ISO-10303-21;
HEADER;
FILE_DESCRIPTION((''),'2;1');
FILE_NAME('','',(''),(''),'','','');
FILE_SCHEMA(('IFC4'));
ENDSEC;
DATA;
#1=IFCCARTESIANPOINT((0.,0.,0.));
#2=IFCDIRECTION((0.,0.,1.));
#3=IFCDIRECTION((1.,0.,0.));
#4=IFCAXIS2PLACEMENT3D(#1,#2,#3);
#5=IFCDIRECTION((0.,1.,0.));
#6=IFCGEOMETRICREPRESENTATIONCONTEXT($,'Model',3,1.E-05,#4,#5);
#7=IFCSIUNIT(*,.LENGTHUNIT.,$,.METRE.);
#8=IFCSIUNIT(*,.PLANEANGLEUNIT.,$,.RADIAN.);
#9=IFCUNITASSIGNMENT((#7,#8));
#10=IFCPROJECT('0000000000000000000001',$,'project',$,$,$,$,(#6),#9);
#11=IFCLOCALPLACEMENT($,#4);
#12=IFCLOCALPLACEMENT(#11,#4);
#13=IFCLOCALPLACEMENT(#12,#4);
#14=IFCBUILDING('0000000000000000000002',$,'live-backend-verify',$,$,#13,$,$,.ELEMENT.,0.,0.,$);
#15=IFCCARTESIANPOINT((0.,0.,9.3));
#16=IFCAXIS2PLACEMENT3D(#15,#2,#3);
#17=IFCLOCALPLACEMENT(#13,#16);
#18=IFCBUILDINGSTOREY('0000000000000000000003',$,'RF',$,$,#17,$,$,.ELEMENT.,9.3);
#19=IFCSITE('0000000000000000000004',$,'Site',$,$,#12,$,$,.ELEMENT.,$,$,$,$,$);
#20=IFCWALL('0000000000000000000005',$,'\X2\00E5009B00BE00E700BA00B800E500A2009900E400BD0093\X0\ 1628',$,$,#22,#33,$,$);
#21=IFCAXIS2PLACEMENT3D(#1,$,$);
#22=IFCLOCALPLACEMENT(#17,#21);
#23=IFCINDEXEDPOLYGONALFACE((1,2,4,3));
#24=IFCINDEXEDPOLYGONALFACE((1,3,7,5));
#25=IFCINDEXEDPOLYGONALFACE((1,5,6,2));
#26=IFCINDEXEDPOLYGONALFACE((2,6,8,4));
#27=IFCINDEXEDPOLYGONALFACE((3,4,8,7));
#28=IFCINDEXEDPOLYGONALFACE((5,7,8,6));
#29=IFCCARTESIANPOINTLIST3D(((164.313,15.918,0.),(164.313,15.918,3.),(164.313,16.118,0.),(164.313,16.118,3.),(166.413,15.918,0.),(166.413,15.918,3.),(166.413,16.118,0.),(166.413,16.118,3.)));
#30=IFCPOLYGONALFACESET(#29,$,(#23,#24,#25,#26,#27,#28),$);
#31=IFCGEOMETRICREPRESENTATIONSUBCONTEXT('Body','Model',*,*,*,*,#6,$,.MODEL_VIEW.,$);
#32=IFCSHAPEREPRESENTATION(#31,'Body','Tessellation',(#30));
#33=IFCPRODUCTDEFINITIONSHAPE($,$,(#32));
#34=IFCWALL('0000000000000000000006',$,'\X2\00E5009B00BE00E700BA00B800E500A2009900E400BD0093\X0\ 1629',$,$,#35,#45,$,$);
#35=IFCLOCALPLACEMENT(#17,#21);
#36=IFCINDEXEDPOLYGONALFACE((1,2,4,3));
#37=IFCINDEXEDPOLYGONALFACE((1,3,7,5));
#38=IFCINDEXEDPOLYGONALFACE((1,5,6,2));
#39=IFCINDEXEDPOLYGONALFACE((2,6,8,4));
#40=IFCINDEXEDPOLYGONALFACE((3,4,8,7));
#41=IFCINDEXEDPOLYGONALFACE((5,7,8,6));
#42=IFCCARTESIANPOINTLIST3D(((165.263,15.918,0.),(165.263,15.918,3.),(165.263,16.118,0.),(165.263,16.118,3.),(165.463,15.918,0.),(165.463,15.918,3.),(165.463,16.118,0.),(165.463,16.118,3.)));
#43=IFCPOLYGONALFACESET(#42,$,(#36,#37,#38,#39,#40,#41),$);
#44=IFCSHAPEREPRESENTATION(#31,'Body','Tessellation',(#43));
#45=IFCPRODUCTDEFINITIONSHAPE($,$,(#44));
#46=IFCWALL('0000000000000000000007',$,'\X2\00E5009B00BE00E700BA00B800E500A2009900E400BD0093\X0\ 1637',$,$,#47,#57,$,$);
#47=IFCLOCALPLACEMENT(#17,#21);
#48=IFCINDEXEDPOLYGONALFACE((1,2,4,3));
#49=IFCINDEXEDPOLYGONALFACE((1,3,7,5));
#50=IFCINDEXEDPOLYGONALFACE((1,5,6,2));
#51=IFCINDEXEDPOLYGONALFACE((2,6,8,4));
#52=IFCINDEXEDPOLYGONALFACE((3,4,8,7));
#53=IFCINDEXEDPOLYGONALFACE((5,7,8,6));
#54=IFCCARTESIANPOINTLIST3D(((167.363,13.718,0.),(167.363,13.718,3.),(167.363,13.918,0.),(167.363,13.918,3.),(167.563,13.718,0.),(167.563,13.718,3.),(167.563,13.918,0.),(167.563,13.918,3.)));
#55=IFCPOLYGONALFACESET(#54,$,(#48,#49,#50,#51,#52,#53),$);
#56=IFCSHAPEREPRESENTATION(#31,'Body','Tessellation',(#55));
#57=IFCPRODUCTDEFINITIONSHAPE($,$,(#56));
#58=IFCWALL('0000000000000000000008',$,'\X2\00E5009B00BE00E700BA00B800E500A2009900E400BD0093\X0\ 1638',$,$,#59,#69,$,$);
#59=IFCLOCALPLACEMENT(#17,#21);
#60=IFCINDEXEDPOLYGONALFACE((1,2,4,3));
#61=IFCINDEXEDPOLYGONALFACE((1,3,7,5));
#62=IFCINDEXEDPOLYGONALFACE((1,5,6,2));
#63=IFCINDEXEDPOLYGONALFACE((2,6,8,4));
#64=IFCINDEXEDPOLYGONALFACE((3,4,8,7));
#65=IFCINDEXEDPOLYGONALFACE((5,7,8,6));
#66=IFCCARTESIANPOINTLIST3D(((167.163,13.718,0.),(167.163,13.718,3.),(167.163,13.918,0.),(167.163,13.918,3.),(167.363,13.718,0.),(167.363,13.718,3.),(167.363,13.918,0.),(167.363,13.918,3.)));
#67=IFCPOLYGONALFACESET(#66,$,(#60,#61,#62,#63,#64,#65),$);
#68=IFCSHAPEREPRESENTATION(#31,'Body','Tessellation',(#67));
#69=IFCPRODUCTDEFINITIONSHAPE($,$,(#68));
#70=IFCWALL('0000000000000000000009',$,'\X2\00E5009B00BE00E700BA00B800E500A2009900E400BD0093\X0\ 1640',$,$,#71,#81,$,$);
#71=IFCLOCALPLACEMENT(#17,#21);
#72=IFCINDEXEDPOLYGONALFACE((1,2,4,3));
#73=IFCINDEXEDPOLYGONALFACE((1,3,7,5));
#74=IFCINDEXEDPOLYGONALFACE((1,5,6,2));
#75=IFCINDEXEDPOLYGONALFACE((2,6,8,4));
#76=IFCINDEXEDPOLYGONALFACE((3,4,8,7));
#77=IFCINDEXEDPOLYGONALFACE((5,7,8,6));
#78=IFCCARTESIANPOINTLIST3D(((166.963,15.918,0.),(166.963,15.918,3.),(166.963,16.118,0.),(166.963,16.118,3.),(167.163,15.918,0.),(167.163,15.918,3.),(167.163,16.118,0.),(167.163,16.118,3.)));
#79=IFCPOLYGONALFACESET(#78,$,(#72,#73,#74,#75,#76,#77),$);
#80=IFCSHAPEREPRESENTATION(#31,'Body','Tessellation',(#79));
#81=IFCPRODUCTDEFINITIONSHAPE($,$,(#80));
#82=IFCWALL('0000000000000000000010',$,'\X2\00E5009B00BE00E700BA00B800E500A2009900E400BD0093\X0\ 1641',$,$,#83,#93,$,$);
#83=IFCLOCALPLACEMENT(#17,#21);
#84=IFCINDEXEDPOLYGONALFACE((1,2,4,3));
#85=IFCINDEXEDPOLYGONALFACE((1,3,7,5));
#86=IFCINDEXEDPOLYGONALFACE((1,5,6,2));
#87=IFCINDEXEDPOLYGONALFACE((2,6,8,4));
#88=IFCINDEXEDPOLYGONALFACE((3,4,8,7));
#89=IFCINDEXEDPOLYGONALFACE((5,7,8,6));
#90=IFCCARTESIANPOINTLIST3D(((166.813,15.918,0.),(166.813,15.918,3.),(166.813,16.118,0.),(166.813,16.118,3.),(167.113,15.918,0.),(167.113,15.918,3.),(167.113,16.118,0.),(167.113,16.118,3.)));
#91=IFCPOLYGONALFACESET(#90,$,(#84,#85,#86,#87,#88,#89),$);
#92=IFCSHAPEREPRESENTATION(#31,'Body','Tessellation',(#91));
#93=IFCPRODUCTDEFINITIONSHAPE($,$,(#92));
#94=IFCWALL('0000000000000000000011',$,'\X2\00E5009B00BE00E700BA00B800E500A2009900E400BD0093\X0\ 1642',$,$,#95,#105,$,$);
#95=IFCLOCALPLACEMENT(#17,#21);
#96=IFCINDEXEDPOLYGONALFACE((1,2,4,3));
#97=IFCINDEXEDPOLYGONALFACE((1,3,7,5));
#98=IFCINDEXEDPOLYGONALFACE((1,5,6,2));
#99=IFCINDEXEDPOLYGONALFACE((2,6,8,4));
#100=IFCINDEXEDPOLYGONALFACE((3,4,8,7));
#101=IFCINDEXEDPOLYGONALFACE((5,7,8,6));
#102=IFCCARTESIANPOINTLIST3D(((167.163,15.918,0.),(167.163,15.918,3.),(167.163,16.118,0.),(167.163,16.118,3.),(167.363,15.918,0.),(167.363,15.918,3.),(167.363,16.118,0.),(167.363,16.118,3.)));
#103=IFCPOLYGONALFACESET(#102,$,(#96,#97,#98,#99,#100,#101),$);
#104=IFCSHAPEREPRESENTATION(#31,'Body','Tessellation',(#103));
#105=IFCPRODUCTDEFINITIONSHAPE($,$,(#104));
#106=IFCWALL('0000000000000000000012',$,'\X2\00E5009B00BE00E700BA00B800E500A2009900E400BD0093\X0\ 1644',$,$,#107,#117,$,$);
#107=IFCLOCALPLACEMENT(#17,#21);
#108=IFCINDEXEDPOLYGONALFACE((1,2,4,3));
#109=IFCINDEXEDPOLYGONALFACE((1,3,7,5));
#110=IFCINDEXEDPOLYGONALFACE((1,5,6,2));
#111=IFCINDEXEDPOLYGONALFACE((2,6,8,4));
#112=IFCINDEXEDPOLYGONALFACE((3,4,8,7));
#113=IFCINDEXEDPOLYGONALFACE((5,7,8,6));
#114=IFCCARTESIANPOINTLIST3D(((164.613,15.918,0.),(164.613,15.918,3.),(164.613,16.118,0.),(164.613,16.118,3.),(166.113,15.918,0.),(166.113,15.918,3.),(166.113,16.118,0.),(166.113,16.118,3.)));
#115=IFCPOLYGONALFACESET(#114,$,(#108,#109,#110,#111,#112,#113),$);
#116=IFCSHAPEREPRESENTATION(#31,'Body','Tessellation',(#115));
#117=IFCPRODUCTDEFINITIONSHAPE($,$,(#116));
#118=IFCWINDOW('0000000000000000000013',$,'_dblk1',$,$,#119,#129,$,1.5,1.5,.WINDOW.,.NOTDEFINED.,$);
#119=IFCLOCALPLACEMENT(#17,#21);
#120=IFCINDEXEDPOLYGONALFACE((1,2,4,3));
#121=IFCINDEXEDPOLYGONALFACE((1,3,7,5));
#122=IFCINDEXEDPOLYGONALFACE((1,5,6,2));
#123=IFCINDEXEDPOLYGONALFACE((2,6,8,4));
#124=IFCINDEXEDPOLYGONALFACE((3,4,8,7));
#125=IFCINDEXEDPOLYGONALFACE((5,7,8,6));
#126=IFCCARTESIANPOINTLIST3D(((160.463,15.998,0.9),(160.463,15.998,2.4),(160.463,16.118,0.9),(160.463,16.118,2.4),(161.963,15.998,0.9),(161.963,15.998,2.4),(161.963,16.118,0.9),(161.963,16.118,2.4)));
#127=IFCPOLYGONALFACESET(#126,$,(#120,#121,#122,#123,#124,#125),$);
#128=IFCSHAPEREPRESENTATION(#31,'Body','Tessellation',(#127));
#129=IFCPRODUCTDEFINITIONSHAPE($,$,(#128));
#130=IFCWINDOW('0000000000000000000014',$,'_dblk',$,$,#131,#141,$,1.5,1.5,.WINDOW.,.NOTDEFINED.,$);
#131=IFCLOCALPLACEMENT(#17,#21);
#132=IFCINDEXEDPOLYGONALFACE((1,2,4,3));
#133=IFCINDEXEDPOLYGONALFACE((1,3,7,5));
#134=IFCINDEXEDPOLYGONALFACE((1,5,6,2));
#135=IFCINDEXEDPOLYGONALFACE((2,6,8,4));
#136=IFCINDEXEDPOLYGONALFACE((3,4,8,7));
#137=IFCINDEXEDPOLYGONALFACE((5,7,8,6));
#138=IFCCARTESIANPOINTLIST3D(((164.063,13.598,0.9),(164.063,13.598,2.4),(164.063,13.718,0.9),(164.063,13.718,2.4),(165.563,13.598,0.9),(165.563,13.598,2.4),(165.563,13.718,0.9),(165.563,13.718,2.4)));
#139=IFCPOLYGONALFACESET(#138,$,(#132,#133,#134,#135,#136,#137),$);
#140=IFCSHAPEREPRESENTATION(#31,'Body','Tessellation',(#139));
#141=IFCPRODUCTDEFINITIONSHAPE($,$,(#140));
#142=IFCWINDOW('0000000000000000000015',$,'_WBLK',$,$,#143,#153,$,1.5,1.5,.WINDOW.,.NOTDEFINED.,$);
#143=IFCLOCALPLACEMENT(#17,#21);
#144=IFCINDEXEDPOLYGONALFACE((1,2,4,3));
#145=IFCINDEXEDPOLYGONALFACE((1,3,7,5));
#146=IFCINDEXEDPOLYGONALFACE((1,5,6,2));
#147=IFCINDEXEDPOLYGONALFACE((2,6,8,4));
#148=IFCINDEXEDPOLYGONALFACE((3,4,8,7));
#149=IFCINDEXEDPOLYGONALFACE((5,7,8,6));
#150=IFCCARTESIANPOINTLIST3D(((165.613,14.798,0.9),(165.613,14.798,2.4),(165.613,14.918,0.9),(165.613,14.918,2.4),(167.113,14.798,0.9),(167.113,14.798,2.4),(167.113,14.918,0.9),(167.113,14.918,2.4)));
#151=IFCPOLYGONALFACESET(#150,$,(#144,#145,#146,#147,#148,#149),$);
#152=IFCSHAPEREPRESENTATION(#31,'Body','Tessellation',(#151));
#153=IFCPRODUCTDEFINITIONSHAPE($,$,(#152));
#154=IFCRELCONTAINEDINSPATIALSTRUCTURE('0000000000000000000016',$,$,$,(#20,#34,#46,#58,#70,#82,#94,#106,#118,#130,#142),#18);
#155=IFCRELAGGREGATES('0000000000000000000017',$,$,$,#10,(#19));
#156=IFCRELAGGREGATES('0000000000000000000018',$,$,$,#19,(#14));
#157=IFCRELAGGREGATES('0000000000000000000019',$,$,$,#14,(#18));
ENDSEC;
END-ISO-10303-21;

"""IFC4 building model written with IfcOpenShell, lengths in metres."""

from ifc_helpers import new_model, si_unit, direction, frame, frame_2d, origin_with_axes, place, context, subcontext, project, spatial, rectangle, extrude, element, save


model = new_model("IFC4")

# Units and contexts
model_context = context("Model", 3, precision=1e-05, world=origin_with_axes(), true_north=direction((0.0, 1.0, 0.0)))
body_context = subcontext(model_context, "Body", "Model", "MODEL_VIEW")
ifc_project = project(units=[si_unit("LENGTHUNIT", "METRE"), si_unit("PLANEANGLEUNIT", "RADIAN")], contexts=[model_context])

# Site, building, storey
placement = place(None, origin_with_axes())
site_placement = place(placement, origin_with_axes())
site = spatial("IfcSite", under=ifc_project, at=site_placement, Name="Site", CompositionType="ELEMENT")
building_placement = place(site_placement, origin_with_axes())
building = spatial("IfcBuilding", under=site, at=building_placement, Name="live-backend-verify", CompositionType="ELEMENT", ElevationOfRefHeight=0.0, ElevationOfTerrain=0.0)
storey_placement = place(building_placement, frame((0.0, 0.0, 9.3), z_axis=(0.0, 0.0, 1.0), x_axis=(1.0, 0.0, 0.0)))
storey = spatial("IfcBuildingStorey", under=building, at=storey_placement, Name="RF", CompositionType="ELEMENT", Elevation=9.3)

# Walls
wall_1_placement = place(storey_placement, frame((165.363, 16.018, 0.0), z_axis=(0.0, 0.0, 1.0), x_axis=(1.0, 0.0, 0.0)))
element("IfcWall", 1, at=wall_1_placement, inside=storey, Name="å\u009b¾çº¸å¢\u0099ä½\u0093 1628", context=body_context, shape_type="SweptSolid", body=[
    extrude(rectangle(XDim=2.1, YDim=0.2, at=frame_2d((0.0, 0.0), x_axis=(1.0, 0.0, 0.0))), frame((0.0, 0.0, 0.0), z_axis=(0.0, 0.0, 1.0)), (0.0, 0.0, 1.0), 3.0),
])
for number, where, z_axis, x_axis, name in (
    (2, (165.363, 16.018, 0.0), (0.0, 0.0, 1.0), (0.0, 1.0, 0.0), "å\u009b¾çº¸å¢\u0099ä½\u0093 1629"),
    (3, (167.463, 13.818, 0.0), (0.0, 0.0, 1.0), (0.0, -1.0, 0.0), "å\u009b¾çº¸å¢\u0099ä½\u0093 1637"),
    (4, (167.263, 13.818, 0.0), (0.0, 0.0, 1.0), (1.0, 0.0, 0.0), "å\u009b¾çº¸å¢\u0099ä½\u0093 1638"),
    (5, (167.063, 16.018, 0.0), (0.0, 0.0, 1.0), (-1.0, 0.0, 0.0), "å\u009b¾çº¸å¢\u0099ä½\u0093 1640"),
):
    element("IfcWall", number, at=place(storey_placement, frame(where, z_axis=z_axis, x_axis=x_axis)), inside=storey, Name=name, context=body_context, shape_type="SweptSolid", body=[
        extrude(rectangle(XDim=0.2, YDim=0.2, at=frame_2d((0.0, 0.0), x_axis=(1.0, 0.0, 0.0))), frame((0.0, 0.0, 0.0), z_axis=(0.0, 0.0, 1.0)), (0.0, 0.0, 1.0), 3.0),
    ])
wall_2_placement = place(storey_placement, frame((166.963, 16.018, 0.0), z_axis=(0.0, 0.0, 1.0), x_axis=(1.0, 0.0, 0.0)))
element("IfcWall", 6, at=wall_2_placement, inside=storey, Name="å\u009b¾çº¸å¢\u0099ä½\u0093 1641", context=body_context, shape_type="SweptSolid", body=[
    extrude(rectangle(XDim=0.3, YDim=0.2, at=frame_2d((0.0, 0.0), x_axis=(1.0, 0.0, 0.0))), frame((0.0, 0.0, 0.0), z_axis=(0.0, 0.0, 1.0)), (0.0, 0.0, 1.0), 3.0),
])
for number, where, z_axis, x_axis, name in (
    (7, (167.263, 16.018, 0.0), (0.0, 0.0, 1.0), (1.0, 0.0, 0.0), "å\u009b¾çº¸å¢\u0099ä½\u0093 1642"),
):
    element("IfcWall", number, at=place(storey_placement, frame(where, z_axis=z_axis, x_axis=x_axis)), inside=storey, Name=name, context=body_context, shape_type="SweptSolid", body=[
        extrude(rectangle(XDim=0.2, YDim=0.2, at=frame_2d((0.0, 0.0), x_axis=(1.0, 0.0, 0.0))), frame((0.0, 0.0, 0.0), z_axis=(0.0, 0.0, 1.0)), (0.0, 0.0, 1.0), 3.0),
    ])
wall_3_placement = place(storey_placement, frame((165.363, 16.018, 0.0), z_axis=(0.0, 0.0, 1.0), x_axis=(-1.0, 0.0, 0.0)))
element("IfcWall", 8, at=wall_3_placement, inside=storey, Name="å\u009b¾çº¸å¢\u0099ä½\u0093 1644", context=body_context, shape_type="SweptSolid", body=[
    extrude(rectangle(XDim=1.5, YDim=0.2, at=frame_2d((0.0, 0.0), x_axis=(1.0, 0.0, 0.0))), frame((0.0, 0.0, 0.0), z_axis=(0.0, 0.0, 1.0)), (0.0, 0.0, 1.0), 3.0),
])

# Windows
for number, where, z_axis, x_axis, name in (
    (9, (161.213, 16.058, 0.9), (0.0, 0.0, 1.0), (1.0, 0.0, 0.0), "_dblk1"),
    (10, (164.813, 13.658, 0.9), (0.0, 0.0, 1.0), (1.0, 0.0, 0.0), "_dblk"),
    (11, (166.363, 14.858, 0.9), (0.0, 0.0, 1.0), (1.0, 0.0, 0.0), "_WBLK"),
):
    element("IfcWindow", number, at=place(storey_placement, frame(where, z_axis=z_axis, x_axis=x_axis)), inside=storey, Name=name, OverallHeight=1.5, OverallWidth=1.5, PartitioningType="NOTDEFINED", PredefinedType="WINDOW", context=body_context, shape_type="SweptSolid", body=[
        extrude(rectangle(XDim=1.5, YDim=0.12, at=frame_2d((0.0, 0.0), x_axis=(1.0, 0.0, 0.0))), frame((0.0, 0.0, 0.0), z_axis=(0.0, 0.0, 1.0)), (0.0, 0.0, 1.0), 1.5),
    ])

save(model, "model.ifc")
